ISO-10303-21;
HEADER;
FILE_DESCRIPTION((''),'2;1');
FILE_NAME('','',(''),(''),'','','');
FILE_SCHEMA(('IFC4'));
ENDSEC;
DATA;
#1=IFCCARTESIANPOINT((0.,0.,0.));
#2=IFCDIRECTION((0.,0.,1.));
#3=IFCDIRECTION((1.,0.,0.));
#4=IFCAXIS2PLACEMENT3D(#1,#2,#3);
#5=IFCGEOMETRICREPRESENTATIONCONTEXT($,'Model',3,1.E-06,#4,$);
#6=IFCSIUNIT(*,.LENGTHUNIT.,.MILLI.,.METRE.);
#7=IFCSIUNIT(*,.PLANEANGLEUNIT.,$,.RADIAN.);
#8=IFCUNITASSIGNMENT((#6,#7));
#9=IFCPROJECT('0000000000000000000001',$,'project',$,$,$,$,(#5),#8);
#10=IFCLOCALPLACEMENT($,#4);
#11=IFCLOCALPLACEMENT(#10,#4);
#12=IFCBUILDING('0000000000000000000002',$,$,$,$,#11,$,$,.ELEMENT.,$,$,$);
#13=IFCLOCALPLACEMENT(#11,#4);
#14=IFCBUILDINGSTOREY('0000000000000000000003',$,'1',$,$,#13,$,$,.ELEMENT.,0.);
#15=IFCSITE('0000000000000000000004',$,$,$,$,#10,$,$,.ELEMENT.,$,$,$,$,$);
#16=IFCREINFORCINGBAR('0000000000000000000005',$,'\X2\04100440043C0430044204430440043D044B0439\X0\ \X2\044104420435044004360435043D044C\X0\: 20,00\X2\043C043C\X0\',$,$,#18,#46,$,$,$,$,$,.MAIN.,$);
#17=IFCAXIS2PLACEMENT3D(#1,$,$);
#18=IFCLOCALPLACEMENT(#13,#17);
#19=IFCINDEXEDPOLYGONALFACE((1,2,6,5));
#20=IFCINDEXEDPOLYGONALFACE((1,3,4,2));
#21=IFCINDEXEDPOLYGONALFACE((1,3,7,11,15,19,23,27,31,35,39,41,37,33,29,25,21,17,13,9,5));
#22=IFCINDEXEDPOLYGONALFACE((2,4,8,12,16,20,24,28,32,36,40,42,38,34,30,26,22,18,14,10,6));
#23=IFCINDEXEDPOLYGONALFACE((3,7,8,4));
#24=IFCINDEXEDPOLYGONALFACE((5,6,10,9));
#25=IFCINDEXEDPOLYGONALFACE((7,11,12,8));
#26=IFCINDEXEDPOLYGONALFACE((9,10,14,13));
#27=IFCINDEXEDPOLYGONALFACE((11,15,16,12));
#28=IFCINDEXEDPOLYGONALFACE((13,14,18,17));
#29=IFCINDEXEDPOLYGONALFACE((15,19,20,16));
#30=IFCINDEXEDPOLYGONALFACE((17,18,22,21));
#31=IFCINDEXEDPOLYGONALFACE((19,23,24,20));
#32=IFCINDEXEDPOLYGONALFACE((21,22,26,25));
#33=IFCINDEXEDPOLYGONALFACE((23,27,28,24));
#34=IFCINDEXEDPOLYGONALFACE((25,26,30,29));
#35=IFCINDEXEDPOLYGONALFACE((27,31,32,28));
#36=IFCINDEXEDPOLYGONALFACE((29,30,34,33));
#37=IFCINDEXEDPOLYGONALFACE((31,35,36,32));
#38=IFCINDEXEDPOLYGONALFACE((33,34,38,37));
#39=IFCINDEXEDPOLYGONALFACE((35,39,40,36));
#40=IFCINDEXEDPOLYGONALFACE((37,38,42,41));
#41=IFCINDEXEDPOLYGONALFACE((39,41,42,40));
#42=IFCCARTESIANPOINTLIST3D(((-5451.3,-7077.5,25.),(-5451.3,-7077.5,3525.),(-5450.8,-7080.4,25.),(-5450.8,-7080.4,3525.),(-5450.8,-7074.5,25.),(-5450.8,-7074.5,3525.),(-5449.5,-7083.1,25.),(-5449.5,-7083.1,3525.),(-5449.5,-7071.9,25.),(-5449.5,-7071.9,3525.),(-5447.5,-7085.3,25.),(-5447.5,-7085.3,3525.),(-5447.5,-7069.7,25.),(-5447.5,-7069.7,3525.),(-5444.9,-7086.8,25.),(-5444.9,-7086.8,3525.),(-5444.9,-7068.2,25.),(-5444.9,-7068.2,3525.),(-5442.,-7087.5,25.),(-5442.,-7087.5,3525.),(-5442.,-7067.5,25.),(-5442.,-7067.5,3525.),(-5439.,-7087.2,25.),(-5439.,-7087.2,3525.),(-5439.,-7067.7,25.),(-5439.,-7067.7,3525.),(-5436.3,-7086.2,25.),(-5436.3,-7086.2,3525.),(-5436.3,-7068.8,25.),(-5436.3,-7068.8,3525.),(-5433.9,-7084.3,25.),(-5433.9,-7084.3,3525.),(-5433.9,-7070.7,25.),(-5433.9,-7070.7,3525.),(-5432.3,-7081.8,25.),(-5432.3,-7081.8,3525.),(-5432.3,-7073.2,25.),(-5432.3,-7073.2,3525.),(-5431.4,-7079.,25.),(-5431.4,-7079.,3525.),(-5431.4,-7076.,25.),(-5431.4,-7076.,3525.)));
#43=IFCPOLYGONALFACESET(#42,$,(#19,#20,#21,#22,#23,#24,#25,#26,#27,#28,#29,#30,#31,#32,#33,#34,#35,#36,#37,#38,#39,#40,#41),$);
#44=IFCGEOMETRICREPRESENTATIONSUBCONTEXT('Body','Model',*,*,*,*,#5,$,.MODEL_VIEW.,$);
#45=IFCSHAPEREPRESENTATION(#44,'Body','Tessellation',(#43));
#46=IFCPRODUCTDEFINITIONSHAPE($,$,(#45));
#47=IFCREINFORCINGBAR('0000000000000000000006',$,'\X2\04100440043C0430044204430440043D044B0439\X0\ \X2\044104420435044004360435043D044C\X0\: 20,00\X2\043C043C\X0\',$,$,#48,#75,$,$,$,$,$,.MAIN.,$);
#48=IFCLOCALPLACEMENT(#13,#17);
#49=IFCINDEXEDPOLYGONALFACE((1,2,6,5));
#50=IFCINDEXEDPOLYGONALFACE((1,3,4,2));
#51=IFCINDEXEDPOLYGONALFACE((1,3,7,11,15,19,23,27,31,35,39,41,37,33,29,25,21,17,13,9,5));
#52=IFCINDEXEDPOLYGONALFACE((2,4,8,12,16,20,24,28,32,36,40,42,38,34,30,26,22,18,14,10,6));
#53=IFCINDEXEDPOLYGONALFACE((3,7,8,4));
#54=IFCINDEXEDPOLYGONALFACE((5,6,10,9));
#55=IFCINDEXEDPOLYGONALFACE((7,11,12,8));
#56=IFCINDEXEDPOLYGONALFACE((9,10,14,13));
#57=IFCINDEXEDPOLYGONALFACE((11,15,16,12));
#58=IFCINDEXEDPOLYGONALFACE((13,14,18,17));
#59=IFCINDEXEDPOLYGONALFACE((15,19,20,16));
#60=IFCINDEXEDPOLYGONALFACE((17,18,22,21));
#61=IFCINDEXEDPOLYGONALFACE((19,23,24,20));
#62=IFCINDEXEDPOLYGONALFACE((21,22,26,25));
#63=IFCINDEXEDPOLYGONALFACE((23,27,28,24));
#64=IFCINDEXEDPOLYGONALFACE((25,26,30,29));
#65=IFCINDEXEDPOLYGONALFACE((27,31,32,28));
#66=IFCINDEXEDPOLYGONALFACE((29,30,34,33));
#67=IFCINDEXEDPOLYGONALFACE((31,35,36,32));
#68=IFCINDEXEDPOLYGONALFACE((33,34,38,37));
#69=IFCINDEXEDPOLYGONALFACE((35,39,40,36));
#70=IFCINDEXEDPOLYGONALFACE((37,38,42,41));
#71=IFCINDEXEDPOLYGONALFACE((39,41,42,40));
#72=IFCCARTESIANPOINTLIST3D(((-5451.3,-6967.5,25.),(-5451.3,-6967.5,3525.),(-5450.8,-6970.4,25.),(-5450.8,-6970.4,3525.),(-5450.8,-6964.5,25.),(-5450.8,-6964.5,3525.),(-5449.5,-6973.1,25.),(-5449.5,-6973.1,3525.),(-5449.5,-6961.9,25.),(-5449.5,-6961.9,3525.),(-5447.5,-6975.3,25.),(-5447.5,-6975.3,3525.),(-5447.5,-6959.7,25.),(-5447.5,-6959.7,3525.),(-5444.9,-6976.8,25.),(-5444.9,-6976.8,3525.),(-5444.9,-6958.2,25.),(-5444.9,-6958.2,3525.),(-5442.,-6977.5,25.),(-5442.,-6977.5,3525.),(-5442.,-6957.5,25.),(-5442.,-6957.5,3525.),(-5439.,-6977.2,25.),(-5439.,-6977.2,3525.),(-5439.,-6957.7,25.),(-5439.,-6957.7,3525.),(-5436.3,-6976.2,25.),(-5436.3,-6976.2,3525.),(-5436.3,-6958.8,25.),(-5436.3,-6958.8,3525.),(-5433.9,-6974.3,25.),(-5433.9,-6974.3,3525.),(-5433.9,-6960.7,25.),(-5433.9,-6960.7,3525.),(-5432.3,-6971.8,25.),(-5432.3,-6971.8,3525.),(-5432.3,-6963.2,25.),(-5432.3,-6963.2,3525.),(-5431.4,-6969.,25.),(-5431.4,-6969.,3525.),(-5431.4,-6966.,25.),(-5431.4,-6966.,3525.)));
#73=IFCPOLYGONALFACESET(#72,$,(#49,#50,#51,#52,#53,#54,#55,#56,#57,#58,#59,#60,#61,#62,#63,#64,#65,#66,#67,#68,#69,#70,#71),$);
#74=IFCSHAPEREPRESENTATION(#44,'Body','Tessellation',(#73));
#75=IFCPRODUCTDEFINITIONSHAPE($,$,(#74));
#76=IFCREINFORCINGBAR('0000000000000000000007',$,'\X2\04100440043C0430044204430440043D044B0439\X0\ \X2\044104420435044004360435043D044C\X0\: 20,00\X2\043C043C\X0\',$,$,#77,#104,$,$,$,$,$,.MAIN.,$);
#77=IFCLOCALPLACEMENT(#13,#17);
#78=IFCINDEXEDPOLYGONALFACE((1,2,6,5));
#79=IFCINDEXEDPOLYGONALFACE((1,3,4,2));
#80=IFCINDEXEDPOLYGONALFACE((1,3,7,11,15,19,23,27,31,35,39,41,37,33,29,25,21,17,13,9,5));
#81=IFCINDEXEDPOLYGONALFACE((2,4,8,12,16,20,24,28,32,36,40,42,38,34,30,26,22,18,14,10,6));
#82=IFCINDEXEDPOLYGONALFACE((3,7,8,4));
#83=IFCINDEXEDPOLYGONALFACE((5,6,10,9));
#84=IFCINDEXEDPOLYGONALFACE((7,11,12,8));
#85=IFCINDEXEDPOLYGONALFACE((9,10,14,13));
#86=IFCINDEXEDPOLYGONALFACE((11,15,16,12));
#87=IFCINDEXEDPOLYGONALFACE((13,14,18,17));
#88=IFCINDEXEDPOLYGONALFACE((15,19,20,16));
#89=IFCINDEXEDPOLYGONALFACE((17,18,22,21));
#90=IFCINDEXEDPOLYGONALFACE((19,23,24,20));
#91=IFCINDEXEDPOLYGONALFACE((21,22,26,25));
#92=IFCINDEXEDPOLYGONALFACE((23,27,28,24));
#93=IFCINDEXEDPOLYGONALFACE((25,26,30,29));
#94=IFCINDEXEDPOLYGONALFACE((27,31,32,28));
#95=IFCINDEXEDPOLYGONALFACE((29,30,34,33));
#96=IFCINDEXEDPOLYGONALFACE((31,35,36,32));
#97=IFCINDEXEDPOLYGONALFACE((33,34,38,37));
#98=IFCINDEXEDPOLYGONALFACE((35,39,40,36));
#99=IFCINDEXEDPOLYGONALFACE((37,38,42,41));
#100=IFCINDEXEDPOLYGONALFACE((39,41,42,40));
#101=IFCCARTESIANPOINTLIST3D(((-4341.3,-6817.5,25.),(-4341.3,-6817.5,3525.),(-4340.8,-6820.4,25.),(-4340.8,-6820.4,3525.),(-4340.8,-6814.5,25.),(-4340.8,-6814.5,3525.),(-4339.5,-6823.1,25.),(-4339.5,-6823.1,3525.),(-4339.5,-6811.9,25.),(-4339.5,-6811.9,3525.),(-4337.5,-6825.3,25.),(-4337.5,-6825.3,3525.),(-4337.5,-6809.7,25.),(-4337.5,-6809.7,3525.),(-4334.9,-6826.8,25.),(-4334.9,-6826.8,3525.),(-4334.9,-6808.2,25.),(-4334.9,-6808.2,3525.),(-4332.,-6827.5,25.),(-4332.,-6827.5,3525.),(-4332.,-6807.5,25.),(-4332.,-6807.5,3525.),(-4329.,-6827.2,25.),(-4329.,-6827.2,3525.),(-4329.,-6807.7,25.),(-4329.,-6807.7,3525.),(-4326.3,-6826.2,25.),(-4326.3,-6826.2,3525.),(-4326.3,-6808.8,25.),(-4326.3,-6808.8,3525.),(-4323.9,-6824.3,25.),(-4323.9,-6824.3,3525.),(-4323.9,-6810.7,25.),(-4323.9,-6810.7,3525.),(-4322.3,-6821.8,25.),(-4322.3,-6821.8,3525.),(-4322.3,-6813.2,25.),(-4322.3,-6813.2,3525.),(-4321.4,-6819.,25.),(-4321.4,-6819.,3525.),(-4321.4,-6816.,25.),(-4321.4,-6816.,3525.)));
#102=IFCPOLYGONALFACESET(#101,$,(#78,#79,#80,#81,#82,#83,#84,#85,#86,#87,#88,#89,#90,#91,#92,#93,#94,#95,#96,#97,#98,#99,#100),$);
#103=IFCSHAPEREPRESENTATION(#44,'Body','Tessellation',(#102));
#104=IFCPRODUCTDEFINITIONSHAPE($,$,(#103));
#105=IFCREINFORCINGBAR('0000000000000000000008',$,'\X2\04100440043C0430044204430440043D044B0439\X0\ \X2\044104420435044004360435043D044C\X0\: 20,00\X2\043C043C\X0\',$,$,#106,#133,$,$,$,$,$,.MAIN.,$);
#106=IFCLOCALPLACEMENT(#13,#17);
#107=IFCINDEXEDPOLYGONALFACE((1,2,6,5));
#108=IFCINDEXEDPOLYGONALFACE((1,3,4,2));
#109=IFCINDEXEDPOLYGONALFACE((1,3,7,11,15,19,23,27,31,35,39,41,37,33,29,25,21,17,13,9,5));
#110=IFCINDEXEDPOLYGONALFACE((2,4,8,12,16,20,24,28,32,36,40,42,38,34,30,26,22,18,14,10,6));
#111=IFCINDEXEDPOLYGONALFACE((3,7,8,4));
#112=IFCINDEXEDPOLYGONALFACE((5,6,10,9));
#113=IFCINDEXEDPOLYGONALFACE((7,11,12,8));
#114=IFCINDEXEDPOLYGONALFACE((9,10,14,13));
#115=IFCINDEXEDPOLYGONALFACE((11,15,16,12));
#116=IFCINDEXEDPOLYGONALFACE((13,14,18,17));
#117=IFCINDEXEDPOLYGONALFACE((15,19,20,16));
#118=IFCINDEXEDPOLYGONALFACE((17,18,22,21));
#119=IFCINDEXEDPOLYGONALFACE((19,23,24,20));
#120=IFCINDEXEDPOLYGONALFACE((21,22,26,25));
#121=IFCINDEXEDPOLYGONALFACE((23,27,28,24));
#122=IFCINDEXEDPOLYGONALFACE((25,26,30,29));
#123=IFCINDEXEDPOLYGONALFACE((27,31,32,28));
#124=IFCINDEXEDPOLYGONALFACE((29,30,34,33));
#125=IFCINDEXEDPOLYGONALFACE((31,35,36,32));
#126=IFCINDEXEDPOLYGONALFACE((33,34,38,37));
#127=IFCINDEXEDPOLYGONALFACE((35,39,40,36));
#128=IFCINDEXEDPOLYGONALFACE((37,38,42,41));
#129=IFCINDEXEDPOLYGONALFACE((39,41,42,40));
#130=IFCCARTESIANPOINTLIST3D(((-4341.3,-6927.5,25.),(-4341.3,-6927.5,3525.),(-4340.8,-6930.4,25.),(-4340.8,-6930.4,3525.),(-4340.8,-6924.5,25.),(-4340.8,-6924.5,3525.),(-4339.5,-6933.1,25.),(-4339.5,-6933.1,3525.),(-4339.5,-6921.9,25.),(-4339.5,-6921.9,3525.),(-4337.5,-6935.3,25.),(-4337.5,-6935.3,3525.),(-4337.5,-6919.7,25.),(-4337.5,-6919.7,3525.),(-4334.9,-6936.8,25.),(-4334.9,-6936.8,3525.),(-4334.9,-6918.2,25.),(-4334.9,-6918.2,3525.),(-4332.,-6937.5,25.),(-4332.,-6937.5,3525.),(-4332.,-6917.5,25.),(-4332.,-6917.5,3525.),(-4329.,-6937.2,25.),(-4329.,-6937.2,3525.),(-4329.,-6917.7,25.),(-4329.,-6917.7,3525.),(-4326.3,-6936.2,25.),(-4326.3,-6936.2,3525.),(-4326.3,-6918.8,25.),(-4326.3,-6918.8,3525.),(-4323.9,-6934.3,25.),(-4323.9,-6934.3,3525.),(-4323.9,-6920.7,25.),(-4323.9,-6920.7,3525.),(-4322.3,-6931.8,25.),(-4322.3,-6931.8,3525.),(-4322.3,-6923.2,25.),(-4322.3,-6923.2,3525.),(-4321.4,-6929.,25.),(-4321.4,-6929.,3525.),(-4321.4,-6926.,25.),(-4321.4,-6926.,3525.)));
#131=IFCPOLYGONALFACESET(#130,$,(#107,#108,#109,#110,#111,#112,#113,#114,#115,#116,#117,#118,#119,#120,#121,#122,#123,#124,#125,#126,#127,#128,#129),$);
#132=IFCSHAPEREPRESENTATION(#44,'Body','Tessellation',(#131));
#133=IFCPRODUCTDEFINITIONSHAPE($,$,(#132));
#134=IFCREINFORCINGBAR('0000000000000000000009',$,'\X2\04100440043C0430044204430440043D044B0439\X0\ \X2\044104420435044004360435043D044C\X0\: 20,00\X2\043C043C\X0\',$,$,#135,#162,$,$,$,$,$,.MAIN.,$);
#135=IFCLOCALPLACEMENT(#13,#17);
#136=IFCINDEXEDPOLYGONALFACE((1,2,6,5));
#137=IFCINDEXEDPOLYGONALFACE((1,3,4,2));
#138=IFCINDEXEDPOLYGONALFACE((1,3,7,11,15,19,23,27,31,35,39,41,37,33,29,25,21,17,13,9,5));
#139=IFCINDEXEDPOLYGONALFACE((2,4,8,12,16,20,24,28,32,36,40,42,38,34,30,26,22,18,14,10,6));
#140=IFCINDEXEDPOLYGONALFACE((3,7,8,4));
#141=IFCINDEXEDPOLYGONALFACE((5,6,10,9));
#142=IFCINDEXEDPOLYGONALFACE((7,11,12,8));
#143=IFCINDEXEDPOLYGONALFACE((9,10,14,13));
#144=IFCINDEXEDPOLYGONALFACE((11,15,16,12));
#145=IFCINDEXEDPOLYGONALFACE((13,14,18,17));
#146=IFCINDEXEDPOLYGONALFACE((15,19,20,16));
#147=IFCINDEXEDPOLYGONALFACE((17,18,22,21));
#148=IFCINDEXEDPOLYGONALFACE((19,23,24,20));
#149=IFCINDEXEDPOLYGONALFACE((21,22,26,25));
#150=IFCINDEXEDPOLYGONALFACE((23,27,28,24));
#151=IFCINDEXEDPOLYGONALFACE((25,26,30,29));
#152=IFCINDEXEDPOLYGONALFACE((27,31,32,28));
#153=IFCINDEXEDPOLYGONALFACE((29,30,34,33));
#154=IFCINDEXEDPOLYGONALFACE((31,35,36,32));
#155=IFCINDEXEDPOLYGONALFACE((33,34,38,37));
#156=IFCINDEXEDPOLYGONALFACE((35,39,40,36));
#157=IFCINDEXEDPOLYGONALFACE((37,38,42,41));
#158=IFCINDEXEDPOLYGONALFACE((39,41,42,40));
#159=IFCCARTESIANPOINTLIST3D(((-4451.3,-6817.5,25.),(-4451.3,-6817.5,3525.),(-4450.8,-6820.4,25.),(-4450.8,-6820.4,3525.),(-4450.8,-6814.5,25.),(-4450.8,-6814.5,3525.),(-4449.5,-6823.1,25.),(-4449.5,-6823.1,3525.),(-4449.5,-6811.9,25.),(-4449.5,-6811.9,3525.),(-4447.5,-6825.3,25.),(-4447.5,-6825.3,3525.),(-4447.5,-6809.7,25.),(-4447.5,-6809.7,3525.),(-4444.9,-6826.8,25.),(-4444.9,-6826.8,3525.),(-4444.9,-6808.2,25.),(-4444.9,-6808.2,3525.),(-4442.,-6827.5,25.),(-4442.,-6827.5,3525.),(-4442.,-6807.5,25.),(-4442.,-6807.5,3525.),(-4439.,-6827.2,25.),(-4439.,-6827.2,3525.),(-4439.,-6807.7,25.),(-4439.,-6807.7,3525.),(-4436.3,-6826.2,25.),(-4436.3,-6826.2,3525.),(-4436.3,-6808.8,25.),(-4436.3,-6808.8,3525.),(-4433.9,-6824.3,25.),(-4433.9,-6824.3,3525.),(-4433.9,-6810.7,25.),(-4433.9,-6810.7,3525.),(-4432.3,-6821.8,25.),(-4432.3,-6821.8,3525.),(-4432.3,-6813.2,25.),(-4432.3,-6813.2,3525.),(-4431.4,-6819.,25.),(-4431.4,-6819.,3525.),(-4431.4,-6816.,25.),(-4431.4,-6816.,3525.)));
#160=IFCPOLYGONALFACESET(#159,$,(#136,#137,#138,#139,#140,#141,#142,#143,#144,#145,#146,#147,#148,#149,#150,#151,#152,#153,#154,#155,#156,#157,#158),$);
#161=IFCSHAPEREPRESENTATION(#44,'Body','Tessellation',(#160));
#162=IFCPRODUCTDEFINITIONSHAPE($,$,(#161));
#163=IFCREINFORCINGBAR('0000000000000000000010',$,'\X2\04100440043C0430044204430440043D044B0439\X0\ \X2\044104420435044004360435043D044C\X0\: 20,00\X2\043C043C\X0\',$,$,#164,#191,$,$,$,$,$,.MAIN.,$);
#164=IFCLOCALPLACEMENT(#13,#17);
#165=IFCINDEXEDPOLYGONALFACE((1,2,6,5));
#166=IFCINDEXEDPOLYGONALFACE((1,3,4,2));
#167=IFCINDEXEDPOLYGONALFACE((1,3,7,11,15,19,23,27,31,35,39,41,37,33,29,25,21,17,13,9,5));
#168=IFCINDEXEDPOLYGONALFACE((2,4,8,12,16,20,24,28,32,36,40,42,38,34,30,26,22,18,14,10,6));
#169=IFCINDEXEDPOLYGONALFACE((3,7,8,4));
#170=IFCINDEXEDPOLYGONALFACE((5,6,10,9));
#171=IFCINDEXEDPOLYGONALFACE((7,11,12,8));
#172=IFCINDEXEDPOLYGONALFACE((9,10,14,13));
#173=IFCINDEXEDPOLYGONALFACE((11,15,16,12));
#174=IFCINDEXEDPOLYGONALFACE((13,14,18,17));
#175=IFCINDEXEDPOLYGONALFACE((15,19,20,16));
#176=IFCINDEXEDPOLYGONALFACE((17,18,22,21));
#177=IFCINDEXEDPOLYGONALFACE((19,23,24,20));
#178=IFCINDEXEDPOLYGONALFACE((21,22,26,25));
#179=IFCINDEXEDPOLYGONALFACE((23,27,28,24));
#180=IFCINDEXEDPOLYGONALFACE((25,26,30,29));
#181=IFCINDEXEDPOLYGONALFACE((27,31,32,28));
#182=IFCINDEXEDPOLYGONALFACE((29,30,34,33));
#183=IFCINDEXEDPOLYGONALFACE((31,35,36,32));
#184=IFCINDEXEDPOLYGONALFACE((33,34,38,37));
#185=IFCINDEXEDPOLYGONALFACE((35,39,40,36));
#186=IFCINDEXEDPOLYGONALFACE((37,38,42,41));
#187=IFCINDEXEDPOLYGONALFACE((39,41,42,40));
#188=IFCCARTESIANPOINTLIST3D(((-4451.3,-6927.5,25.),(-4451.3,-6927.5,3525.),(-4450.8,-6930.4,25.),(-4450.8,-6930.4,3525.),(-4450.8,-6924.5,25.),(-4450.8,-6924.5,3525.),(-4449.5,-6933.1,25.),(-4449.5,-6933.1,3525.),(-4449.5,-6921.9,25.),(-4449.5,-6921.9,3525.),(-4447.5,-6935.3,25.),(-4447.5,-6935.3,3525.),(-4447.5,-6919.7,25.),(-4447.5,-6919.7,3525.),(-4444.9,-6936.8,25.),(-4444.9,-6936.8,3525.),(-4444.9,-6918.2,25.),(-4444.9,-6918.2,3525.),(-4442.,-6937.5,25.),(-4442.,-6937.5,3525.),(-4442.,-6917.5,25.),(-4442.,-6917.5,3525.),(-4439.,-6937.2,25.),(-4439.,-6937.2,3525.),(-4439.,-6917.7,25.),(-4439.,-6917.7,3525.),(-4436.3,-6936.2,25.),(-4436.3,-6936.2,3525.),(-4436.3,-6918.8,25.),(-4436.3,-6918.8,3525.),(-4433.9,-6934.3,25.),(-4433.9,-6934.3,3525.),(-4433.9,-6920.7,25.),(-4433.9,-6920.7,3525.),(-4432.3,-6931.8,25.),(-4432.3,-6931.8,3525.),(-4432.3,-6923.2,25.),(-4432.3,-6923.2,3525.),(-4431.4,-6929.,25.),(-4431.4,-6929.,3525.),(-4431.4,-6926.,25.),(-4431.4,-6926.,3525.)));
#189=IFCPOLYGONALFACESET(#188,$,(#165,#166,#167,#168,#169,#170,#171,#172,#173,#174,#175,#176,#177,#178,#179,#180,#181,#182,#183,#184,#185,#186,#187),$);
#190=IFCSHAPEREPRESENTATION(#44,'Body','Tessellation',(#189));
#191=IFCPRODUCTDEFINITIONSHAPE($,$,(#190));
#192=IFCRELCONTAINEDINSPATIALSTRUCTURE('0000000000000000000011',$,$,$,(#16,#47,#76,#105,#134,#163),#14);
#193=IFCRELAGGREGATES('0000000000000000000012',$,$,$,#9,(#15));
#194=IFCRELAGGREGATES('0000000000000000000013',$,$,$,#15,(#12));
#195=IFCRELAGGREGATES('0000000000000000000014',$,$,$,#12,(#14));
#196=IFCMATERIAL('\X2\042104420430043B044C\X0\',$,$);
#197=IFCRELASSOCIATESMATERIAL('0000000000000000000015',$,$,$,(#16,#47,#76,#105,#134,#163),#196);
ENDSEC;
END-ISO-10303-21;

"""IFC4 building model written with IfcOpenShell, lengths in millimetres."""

from ifc_helpers import new_model, entity, si_unit, origin_with_axes, place, context, subcontext, project, spatial, source, transform, mapped, material, element, save


model = new_model("IFC4")

# Units and contexts
model_context = context("Model", 3, precision=1e-06, world=origin_with_axes())
body_context = subcontext(model_context, "Body", "Model", "MODEL_VIEW")
ifc_project = project(units=[si_unit("LENGTHUNIT", "METRE", prefix="MILLI"), si_unit("PLANEANGLEUNIT", "RADIAN")], contexts=[model_context])

# Site, building, storey
site_placement = place(None, origin_with_axes())
site = spatial("IfcSite", under=ifc_project, at=site_placement, CompositionType="ELEMENT")
building_placement = place(site_placement, origin_with_axes())
building = spatial("IfcBuilding", under=site, at=building_placement, CompositionType="ELEMENT")
storey_placement = place(building_placement, origin_with_axes())
storey = spatial("IfcBuildingStorey", under=building, at=storey_placement, Name="1", CompositionType="ELEMENT", Elevation=0.0)

# Reinforcing bars
ifc_material = material(Name="Сталь")
shared_shape_1 = source(origin_with_axes(), body_context, "Body", "AdvancedSweptSolid", [
    entity("IfcSweptDiskSolid", entity("IfcIndexedPolyCurve", entity("IfcCartesianPointList3D", [[0.0, 0.0, 0.0], [3500.0, 0.0, 0.0]]), [entity("IfcLineIndex", [1, 2])]), 10.0),
])
reinforcing_bar_1_placement = place(storey_placement, origin_with_axes())
element("IfcReinforcingBar", 1, at=reinforcing_bar_1_placement, inside=storey, material=ifc_material, Name="Арматурный стержень: 20,00мм", PredefinedType="MAIN", context=body_context, shape_type="MappedRepresentation", body=[
    mapped(shared_shape_1, transform((-5441.3, -7077.5, 25.0), x_axis=(0.0, 0.0, 1.0), y_axis=(0.0, 1.0, 0.0), z_axis=(-1.0, 0.0, 0.0), scale=1.0)),
])
reinforcing_bar_2_placement = place(storey_placement, origin_with_axes())
element("IfcReinforcingBar", 2, at=reinforcing_bar_2_placement, inside=storey, material=ifc_material, Name="Арматурный стержень: 20,00мм", PredefinedType="MAIN", context=body_context, shape_type="MappedRepresentation", body=[
    mapped(shared_shape_1, transform((-5441.3, -6967.5, 25.0), x_axis=(0.0, 0.0, 1.0), y_axis=(0.0, 1.0, 0.0), z_axis=(-1.0, 0.0, 0.0), scale=1.0)),
])
reinforcing_bar_3_placement = place(storey_placement, origin_with_axes())
element("IfcReinforcingBar", 3, at=reinforcing_bar_3_placement, inside=storey, material=ifc_material, Name="Арматурный стержень: 20,00мм", PredefinedType="MAIN", context=body_context, shape_type="MappedRepresentation", body=[
    mapped(shared_shape_1, transform((-4331.3, -6817.5, 25.0), x_axis=(0.0, 0.0, 1.0), y_axis=(0.0, 1.0, 0.0), z_axis=(-1.0, 0.0, 0.0), scale=1.0)),
])
reinforcing_bar_4_placement = place(storey_placement, origin_with_axes())
element("IfcReinforcingBar", 4, at=reinforcing_bar_4_placement, inside=storey, material=ifc_material, Name="Арматурный стержень: 20,00мм", PredefinedType="MAIN", context=body_context, shape_type="MappedRepresentation", body=[
    mapped(shared_shape_1, transform((-4331.3, -6927.5, 25.0), x_axis=(0.0, 0.0, 1.0), y_axis=(0.0, 1.0, 0.0), z_axis=(-1.0, 0.0, 0.0), scale=1.0)),
])
reinforcing_bar_5_placement = place(storey_placement, origin_with_axes())
element("IfcReinforcingBar", 5, at=reinforcing_bar_5_placement, inside=storey, material=ifc_material, Name="Арматурный стержень: 20,00мм", PredefinedType="MAIN", context=body_context, shape_type="MappedRepresentation", body=[
    mapped(shared_shape_1, transform((-4441.3, -6817.5, 25.0), x_axis=(0.0, 0.0, 1.0), y_axis=(0.0, 1.0, 0.0), z_axis=(-1.0, 0.0, 0.0), scale=1.0)),
])
reinforcing_bar_6_placement = place(storey_placement, origin_with_axes())
element("IfcReinforcingBar", 6, at=reinforcing_bar_6_placement, inside=storey, material=ifc_material, Name="Арматурный стержень: 20,00мм", PredefinedType="MAIN", context=body_context, shape_type="MappedRepresentation", body=[
    mapped(shared_shape_1, transform((-4441.3, -6927.5, 25.0), x_axis=(0.0, 0.0, 1.0), y_axis=(0.0, 1.0, 0.0), z_axis=(-1.0, 0.0, 0.0), scale=1.0)),
])

save(model, "model.ifc")
